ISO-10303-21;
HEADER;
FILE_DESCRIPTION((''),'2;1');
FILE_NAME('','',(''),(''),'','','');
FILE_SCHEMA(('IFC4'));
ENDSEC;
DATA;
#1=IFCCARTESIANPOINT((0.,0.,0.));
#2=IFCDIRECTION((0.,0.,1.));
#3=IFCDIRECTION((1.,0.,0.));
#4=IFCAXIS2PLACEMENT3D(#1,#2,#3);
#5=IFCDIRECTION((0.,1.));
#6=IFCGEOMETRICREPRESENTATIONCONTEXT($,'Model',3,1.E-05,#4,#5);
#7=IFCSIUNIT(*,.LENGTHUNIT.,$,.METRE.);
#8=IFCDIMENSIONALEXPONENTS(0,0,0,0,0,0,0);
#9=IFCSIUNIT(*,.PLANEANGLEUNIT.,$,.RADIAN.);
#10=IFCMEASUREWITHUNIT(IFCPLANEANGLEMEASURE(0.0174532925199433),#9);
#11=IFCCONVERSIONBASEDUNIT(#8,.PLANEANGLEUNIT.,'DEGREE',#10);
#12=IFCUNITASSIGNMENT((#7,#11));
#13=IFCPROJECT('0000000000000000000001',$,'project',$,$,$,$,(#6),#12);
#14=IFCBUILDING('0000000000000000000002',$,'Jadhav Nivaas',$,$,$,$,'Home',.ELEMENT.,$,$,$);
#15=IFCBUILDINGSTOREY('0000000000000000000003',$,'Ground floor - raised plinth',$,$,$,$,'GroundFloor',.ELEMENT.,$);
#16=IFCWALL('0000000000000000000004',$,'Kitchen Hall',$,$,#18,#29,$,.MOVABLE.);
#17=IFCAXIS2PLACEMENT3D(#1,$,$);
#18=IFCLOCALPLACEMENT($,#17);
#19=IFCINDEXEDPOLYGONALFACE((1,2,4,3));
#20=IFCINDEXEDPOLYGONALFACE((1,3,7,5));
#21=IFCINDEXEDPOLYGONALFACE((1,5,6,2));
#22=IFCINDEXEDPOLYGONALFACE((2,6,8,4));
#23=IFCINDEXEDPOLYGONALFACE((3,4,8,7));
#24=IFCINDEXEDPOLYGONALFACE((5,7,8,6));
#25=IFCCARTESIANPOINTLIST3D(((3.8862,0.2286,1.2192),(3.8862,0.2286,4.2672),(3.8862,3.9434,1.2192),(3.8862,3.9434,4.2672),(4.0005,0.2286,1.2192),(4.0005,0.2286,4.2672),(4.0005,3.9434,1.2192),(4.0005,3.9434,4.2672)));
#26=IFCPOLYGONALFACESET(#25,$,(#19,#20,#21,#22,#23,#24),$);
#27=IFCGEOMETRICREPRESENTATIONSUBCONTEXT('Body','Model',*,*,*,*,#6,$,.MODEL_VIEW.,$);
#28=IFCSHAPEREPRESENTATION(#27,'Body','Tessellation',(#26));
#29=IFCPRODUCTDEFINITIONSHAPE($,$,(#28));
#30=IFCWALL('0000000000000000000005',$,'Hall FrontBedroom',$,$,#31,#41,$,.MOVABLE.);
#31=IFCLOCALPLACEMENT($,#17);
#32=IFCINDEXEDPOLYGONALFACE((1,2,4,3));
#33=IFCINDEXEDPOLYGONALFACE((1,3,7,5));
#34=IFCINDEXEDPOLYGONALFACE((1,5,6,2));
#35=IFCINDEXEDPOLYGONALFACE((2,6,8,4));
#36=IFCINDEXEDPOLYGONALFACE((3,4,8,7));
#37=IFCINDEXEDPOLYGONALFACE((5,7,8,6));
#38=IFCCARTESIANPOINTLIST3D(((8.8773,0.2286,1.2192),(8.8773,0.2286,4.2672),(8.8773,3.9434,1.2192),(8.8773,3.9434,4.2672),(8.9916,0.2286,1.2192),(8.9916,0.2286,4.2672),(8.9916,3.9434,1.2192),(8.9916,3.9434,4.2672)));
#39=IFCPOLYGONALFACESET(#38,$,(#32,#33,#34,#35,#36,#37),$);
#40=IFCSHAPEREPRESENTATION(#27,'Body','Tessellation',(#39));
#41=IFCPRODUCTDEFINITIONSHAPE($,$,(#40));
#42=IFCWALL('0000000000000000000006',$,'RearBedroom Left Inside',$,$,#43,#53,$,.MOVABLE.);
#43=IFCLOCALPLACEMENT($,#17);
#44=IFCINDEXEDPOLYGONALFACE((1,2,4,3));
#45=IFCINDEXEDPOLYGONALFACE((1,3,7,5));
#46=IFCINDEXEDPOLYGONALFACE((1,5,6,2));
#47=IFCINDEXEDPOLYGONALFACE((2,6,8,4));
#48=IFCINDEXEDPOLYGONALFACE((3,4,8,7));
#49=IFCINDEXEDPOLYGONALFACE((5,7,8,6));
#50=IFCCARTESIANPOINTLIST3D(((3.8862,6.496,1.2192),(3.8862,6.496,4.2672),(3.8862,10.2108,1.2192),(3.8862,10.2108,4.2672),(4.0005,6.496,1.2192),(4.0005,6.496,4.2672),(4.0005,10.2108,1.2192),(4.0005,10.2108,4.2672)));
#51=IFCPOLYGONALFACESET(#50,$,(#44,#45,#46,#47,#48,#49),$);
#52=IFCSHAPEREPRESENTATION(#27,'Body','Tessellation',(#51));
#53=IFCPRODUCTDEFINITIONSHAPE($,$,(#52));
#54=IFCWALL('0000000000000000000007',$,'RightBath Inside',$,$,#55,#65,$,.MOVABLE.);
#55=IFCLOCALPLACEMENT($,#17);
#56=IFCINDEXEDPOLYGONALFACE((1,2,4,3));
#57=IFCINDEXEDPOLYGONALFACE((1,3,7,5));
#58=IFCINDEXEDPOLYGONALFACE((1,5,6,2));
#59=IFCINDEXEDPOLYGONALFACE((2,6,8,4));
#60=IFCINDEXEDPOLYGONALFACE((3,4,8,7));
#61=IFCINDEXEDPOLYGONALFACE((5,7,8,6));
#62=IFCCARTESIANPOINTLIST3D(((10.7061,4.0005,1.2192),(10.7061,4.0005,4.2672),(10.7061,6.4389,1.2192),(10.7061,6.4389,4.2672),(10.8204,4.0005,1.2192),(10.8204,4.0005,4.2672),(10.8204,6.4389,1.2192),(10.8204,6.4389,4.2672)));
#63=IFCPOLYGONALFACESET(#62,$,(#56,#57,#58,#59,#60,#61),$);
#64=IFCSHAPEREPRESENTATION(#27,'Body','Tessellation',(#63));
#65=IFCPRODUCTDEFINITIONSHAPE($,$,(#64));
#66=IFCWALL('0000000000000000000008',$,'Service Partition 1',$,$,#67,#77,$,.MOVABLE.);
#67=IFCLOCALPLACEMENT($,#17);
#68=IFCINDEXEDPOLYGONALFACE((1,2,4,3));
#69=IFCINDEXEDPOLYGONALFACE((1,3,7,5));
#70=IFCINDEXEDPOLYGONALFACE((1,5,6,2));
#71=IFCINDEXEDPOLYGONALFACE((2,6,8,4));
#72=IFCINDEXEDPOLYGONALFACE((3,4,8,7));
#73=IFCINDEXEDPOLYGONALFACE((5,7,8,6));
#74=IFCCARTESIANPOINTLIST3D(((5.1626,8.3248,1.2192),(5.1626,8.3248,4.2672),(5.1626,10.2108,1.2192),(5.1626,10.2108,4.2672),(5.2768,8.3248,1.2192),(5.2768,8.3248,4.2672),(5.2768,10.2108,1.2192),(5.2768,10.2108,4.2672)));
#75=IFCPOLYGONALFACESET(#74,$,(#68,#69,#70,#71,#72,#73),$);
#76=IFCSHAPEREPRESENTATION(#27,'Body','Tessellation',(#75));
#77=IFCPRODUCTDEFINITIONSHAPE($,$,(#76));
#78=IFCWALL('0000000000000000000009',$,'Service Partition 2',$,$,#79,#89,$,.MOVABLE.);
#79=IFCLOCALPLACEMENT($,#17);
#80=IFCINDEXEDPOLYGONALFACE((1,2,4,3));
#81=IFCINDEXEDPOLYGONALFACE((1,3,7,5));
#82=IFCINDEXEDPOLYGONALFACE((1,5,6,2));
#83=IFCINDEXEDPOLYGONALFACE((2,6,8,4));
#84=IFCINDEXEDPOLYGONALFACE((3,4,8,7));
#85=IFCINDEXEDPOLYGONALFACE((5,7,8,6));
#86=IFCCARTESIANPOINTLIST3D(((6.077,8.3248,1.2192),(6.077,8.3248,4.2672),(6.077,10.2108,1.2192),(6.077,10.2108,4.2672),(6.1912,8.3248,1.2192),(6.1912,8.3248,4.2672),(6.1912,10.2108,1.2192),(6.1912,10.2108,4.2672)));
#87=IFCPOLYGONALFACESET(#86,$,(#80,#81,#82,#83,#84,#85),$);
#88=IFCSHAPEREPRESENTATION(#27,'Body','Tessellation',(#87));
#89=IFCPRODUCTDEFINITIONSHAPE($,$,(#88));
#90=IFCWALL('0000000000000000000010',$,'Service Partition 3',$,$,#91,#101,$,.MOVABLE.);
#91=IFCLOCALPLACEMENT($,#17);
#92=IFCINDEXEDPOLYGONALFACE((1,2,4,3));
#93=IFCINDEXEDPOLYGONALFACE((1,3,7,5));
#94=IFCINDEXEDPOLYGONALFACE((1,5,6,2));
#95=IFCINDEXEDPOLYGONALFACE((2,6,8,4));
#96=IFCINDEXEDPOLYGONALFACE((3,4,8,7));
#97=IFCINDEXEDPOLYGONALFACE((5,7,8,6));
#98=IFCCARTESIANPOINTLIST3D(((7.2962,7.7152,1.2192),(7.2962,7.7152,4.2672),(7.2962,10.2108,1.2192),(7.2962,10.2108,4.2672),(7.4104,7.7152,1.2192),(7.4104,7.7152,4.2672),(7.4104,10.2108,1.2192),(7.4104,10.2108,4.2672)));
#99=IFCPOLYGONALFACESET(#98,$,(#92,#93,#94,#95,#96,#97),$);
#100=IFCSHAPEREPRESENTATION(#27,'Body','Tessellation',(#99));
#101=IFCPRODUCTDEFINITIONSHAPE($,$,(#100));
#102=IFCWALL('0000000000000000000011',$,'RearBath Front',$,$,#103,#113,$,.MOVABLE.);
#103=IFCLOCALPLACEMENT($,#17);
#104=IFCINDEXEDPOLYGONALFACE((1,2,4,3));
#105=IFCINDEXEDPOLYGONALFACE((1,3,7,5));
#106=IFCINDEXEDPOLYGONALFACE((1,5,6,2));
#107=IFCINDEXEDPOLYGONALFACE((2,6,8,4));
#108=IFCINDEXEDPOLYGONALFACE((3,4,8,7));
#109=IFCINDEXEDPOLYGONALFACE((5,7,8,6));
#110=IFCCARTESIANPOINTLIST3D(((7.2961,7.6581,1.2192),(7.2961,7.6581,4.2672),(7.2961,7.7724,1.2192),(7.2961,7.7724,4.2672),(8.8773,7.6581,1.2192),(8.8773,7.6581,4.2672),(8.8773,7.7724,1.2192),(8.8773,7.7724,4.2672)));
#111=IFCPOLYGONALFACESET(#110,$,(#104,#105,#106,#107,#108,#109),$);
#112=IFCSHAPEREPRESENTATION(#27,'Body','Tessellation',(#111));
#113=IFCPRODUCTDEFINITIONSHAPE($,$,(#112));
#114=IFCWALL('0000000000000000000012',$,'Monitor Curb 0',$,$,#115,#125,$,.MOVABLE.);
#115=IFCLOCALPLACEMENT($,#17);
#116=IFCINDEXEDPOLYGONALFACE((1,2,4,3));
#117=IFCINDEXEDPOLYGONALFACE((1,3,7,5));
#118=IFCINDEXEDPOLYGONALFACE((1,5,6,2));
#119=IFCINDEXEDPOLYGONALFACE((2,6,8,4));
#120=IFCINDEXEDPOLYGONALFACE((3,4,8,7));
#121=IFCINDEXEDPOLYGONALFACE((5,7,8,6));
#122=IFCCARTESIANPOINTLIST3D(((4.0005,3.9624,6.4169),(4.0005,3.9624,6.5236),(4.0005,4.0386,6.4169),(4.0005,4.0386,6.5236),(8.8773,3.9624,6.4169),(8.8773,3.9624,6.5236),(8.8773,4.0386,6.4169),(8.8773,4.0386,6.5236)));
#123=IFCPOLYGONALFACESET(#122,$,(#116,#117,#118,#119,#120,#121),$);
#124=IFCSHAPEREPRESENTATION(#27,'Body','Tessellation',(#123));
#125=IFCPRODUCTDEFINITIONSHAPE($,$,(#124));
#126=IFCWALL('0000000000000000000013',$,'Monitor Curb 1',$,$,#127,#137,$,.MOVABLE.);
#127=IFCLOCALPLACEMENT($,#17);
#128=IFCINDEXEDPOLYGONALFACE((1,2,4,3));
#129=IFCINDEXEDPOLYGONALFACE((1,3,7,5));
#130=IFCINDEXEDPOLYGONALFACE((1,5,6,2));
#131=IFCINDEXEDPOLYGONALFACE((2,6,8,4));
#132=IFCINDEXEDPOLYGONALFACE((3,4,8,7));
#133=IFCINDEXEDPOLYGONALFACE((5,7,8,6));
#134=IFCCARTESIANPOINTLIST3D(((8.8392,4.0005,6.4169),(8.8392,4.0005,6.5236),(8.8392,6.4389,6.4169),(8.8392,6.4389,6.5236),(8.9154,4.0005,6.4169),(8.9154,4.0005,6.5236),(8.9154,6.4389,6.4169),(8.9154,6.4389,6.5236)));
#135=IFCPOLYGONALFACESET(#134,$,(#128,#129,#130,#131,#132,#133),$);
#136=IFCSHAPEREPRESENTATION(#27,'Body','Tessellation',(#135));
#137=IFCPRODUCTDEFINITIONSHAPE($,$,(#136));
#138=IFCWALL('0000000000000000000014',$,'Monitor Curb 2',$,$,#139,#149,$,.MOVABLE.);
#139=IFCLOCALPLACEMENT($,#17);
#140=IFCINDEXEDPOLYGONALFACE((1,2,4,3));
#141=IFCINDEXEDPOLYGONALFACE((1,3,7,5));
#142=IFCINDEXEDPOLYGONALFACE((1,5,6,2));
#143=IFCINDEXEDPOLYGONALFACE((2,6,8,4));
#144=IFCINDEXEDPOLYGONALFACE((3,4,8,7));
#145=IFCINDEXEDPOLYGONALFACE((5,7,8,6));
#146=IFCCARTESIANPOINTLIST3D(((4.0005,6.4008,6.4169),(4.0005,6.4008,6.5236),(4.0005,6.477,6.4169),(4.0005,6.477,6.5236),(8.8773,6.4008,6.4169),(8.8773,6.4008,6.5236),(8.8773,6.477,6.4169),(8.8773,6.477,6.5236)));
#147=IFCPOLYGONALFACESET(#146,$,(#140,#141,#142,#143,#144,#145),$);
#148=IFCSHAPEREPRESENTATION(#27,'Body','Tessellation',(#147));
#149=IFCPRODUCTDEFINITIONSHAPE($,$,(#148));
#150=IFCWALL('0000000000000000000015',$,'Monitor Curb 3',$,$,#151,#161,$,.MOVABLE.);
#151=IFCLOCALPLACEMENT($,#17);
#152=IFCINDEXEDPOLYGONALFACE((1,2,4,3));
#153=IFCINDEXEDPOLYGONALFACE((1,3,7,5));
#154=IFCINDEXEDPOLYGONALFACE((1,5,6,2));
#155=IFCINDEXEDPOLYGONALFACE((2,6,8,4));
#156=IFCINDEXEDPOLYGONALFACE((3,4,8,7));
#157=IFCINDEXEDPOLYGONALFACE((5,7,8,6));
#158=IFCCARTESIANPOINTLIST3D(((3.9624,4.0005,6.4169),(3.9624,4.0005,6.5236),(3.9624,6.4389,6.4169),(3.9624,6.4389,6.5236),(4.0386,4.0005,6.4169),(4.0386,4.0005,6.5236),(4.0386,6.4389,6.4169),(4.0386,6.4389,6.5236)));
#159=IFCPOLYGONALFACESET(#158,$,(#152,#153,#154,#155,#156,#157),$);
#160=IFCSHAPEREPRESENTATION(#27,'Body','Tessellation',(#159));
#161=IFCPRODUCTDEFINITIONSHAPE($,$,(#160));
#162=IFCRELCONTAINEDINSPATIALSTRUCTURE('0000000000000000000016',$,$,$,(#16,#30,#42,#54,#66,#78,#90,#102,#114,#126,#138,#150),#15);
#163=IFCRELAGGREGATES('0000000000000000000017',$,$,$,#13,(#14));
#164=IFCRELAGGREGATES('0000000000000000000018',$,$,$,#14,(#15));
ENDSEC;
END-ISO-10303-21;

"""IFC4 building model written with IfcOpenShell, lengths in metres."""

from ifc_helpers import new_model, entity, si_unit, converted_unit, direction, frame, frame_2d, origin_with_axes, origin_2d_with_axis, place, context, subcontext, project, spatial, rectangle, extrude, element, save


model = new_model("IFC4")

# Units and contexts
model_context = context("Model", 3, precision=1e-05, world=origin_with_axes(), true_north=direction((0.0, 1.0)))
body_context = subcontext(model_context, "Body", "Model", "MODEL_VIEW")
ifc_project = project(units=[si_unit("LENGTHUNIT", "METRE"), converted_unit("PLANEANGLEUNIT", "DEGREE", entity("IfcPlaneAngleMeasure", 0.0174532925199433), si_unit("PLANEANGLEUNIT", "RADIAN"), dimensions=[0, 0, 0, 0, 0, 0, 0])], contexts=[model_context])

# Building, storey
building = spatial("IfcBuilding", under=ifc_project, Name="Jadhav Nivaas", LongName="Home", CompositionType="ELEMENT")
storey = spatial("IfcBuildingStorey", under=building, Name="Ground floor - raised plinth", LongName="GroundFloor", CompositionType="ELEMENT")

# Walls
placement = place(None, origin_with_axes())
element("IfcWall", 1, at=placement, inside=storey, Name="Kitchen Hall", PredefinedType="MOVABLE", context=body_context, shape_type="SweptSolid", body=[
    extrude(rectangle(XDim=3.7147, YDim=0.1143, at=frame_2d((0.0, 0.0), x_axis=(0.0, 1.0))), frame((3.9434, 2.086, 1.2192), z_axis=(0.0, 0.0, 1.0), x_axis=(1.0, 0.0, 0.0)), (0.0, 0.0, 1.0), 3.048),
])
element("IfcWall", 2, at=placement, inside=storey, Name="Hall FrontBedroom", PredefinedType="MOVABLE", context=body_context, shape_type="SweptSolid", body=[
    extrude(rectangle(XDim=3.7147, YDim=0.1143, at=frame_2d((0.0, 0.0), x_axis=(0.0, 1.0))), frame((8.9345, 2.086, 1.2192), z_axis=(0.0, 0.0, 1.0), x_axis=(1.0, 0.0, 0.0)), (0.0, 0.0, 1.0), 3.048),
])
element("IfcWall", 3, at=placement, inside=storey, Name="RearBedroom Left Inside", PredefinedType="MOVABLE", context=body_context, shape_type="SweptSolid", body=[
    extrude(rectangle(XDim=3.7147, YDim=0.1143, at=frame_2d((0.0, 0.0), x_axis=(0.0, 1.0))), frame((3.9434, 8.3534, 1.2192), z_axis=(0.0, 0.0, 1.0), x_axis=(1.0, 0.0, 0.0)), (0.0, 0.0, 1.0), 3.048),
])
element("IfcWall", 4, at=placement, inside=storey, Name="RightBath Inside", PredefinedType="MOVABLE", context=body_context, shape_type="SweptSolid", body=[
    extrude(rectangle(XDim=2.4384, YDim=0.1143, at=frame_2d((0.0, 0.0), x_axis=(0.0, 1.0))), frame((10.7632, 5.2197, 1.2192), z_axis=(0.0, 0.0, 1.0), x_axis=(1.0, 0.0, 0.0)), (0.0, 0.0, 1.0), 3.048),
])
element("IfcWall", 5, at=placement, inside=storey, Name="Service Partition 1", PredefinedType="MOVABLE", context=body_context, shape_type="SweptSolid", body=[
    extrude(rectangle(XDim=1.886, YDim=0.1143, at=frame_2d((0.0, 0.0), x_axis=(0.0, 1.0))), frame((5.2197, 9.2678, 1.2192), z_axis=(0.0, 0.0, 1.0), x_axis=(1.0, 0.0, 0.0)), (0.0, 0.0, 1.0), 3.048),
])
element("IfcWall", 6, at=placement, inside=storey, Name="Service Partition 2", PredefinedType="MOVABLE", context=body_context, shape_type="SweptSolid", body=[
    extrude(rectangle(XDim=1.886, YDim=0.1143, at=frame_2d((0.0, 0.0), x_axis=(0.0, 1.0))), frame((6.1341, 9.2678, 1.2192), z_axis=(0.0, 0.0, 1.0), x_axis=(1.0, 0.0, 0.0)), (0.0, 0.0, 1.0), 3.048),
])
element("IfcWall", 7, at=placement, inside=storey, Name="Service Partition 3", PredefinedType="MOVABLE", context=body_context, shape_type="SweptSolid", body=[
    extrude(rectangle(XDim=2.4956, YDim=0.1143, at=frame_2d((0.0, 0.0), x_axis=(0.0, 1.0))), frame((7.3533, 8.963, 1.2192), z_axis=(0.0, 0.0, 1.0), x_axis=(1.0, 0.0, 0.0)), (0.0, 0.0, 1.0), 3.048),
])
element("IfcWall", 8, at=placement, inside=storey, Name="RearBath Front", PredefinedType="MOVABLE", context=body_context, shape_type="SweptSolid", body=[
    extrude(rectangle(XDim=1.5812, YDim=0.1143, at=origin_2d_with_axis()), frame((8.0867, 7.7153, 1.2192), z_axis=(0.0, 0.0, 1.0), x_axis=(1.0, 0.0, 0.0)), (0.0, 0.0, 1.0), 3.048),
])
element("IfcWall", 9, at=placement, inside=storey, Name="Monitor Curb 0", PredefinedType="MOVABLE", context=body_context, shape_type="SweptSolid", body=[
    extrude(rectangle(XDim=4.8768, YDim=0.0762, at=frame_2d((0.0, 0.0), x_axis=(1.0, 0.0))), frame((6.4389, 4.0005, 6.4169), z_axis=(0.0, 0.0, 1.0), x_axis=(1.0, 0.0, 0.0)), (0.0, 0.0, 1.0), 0.1067),
])
element("IfcWall", 10, at=placement, inside=storey, Name="Monitor Curb 1", PredefinedType="MOVABLE", context=body_context, shape_type="SweptSolid", body=[
    extrude(rectangle(XDim=2.4384, YDim=0.0762, at=frame_2d((0.0, 0.0), x_axis=(0.0, 1.0))), frame((8.8773, 5.2197, 6.4169), z_axis=(0.0, 0.0, 1.0), x_axis=(1.0, 0.0, 0.0)), (0.0, 0.0, 1.0), 0.1067),
])
element("IfcWall", 11, at=placement, inside=storey, Name="Monitor Curb 2", PredefinedType="MOVABLE", context=body_context, shape_type="SweptSolid", body=[
    extrude(rectangle(XDim=4.8768, YDim=0.0762, at=origin_2d_with_axis()), frame((6.4389, 6.4389, 6.4169), z_axis=(0.0, 0.0, 1.0), x_axis=(1.0, 0.0, 0.0)), (0.0, 0.0, 1.0), 0.1067),
])
element("IfcWall", 12, at=placement, inside=storey, Name="Monitor Curb 3", PredefinedType="MOVABLE", context=body_context, shape_type="SweptSolid", body=[
    extrude(rectangle(XDim=2.4384, YDim=0.0762, at=frame_2d((0.0, 0.0), x_axis=(0.0, 1.0))), frame((4.0005, 5.2197, 6.4169), z_axis=(0.0, 0.0, 1.0), x_axis=(1.0, 0.0, 0.0)), (0.0, 0.0, 1.0), 0.1067),
])

save(model, "model.ifc")
